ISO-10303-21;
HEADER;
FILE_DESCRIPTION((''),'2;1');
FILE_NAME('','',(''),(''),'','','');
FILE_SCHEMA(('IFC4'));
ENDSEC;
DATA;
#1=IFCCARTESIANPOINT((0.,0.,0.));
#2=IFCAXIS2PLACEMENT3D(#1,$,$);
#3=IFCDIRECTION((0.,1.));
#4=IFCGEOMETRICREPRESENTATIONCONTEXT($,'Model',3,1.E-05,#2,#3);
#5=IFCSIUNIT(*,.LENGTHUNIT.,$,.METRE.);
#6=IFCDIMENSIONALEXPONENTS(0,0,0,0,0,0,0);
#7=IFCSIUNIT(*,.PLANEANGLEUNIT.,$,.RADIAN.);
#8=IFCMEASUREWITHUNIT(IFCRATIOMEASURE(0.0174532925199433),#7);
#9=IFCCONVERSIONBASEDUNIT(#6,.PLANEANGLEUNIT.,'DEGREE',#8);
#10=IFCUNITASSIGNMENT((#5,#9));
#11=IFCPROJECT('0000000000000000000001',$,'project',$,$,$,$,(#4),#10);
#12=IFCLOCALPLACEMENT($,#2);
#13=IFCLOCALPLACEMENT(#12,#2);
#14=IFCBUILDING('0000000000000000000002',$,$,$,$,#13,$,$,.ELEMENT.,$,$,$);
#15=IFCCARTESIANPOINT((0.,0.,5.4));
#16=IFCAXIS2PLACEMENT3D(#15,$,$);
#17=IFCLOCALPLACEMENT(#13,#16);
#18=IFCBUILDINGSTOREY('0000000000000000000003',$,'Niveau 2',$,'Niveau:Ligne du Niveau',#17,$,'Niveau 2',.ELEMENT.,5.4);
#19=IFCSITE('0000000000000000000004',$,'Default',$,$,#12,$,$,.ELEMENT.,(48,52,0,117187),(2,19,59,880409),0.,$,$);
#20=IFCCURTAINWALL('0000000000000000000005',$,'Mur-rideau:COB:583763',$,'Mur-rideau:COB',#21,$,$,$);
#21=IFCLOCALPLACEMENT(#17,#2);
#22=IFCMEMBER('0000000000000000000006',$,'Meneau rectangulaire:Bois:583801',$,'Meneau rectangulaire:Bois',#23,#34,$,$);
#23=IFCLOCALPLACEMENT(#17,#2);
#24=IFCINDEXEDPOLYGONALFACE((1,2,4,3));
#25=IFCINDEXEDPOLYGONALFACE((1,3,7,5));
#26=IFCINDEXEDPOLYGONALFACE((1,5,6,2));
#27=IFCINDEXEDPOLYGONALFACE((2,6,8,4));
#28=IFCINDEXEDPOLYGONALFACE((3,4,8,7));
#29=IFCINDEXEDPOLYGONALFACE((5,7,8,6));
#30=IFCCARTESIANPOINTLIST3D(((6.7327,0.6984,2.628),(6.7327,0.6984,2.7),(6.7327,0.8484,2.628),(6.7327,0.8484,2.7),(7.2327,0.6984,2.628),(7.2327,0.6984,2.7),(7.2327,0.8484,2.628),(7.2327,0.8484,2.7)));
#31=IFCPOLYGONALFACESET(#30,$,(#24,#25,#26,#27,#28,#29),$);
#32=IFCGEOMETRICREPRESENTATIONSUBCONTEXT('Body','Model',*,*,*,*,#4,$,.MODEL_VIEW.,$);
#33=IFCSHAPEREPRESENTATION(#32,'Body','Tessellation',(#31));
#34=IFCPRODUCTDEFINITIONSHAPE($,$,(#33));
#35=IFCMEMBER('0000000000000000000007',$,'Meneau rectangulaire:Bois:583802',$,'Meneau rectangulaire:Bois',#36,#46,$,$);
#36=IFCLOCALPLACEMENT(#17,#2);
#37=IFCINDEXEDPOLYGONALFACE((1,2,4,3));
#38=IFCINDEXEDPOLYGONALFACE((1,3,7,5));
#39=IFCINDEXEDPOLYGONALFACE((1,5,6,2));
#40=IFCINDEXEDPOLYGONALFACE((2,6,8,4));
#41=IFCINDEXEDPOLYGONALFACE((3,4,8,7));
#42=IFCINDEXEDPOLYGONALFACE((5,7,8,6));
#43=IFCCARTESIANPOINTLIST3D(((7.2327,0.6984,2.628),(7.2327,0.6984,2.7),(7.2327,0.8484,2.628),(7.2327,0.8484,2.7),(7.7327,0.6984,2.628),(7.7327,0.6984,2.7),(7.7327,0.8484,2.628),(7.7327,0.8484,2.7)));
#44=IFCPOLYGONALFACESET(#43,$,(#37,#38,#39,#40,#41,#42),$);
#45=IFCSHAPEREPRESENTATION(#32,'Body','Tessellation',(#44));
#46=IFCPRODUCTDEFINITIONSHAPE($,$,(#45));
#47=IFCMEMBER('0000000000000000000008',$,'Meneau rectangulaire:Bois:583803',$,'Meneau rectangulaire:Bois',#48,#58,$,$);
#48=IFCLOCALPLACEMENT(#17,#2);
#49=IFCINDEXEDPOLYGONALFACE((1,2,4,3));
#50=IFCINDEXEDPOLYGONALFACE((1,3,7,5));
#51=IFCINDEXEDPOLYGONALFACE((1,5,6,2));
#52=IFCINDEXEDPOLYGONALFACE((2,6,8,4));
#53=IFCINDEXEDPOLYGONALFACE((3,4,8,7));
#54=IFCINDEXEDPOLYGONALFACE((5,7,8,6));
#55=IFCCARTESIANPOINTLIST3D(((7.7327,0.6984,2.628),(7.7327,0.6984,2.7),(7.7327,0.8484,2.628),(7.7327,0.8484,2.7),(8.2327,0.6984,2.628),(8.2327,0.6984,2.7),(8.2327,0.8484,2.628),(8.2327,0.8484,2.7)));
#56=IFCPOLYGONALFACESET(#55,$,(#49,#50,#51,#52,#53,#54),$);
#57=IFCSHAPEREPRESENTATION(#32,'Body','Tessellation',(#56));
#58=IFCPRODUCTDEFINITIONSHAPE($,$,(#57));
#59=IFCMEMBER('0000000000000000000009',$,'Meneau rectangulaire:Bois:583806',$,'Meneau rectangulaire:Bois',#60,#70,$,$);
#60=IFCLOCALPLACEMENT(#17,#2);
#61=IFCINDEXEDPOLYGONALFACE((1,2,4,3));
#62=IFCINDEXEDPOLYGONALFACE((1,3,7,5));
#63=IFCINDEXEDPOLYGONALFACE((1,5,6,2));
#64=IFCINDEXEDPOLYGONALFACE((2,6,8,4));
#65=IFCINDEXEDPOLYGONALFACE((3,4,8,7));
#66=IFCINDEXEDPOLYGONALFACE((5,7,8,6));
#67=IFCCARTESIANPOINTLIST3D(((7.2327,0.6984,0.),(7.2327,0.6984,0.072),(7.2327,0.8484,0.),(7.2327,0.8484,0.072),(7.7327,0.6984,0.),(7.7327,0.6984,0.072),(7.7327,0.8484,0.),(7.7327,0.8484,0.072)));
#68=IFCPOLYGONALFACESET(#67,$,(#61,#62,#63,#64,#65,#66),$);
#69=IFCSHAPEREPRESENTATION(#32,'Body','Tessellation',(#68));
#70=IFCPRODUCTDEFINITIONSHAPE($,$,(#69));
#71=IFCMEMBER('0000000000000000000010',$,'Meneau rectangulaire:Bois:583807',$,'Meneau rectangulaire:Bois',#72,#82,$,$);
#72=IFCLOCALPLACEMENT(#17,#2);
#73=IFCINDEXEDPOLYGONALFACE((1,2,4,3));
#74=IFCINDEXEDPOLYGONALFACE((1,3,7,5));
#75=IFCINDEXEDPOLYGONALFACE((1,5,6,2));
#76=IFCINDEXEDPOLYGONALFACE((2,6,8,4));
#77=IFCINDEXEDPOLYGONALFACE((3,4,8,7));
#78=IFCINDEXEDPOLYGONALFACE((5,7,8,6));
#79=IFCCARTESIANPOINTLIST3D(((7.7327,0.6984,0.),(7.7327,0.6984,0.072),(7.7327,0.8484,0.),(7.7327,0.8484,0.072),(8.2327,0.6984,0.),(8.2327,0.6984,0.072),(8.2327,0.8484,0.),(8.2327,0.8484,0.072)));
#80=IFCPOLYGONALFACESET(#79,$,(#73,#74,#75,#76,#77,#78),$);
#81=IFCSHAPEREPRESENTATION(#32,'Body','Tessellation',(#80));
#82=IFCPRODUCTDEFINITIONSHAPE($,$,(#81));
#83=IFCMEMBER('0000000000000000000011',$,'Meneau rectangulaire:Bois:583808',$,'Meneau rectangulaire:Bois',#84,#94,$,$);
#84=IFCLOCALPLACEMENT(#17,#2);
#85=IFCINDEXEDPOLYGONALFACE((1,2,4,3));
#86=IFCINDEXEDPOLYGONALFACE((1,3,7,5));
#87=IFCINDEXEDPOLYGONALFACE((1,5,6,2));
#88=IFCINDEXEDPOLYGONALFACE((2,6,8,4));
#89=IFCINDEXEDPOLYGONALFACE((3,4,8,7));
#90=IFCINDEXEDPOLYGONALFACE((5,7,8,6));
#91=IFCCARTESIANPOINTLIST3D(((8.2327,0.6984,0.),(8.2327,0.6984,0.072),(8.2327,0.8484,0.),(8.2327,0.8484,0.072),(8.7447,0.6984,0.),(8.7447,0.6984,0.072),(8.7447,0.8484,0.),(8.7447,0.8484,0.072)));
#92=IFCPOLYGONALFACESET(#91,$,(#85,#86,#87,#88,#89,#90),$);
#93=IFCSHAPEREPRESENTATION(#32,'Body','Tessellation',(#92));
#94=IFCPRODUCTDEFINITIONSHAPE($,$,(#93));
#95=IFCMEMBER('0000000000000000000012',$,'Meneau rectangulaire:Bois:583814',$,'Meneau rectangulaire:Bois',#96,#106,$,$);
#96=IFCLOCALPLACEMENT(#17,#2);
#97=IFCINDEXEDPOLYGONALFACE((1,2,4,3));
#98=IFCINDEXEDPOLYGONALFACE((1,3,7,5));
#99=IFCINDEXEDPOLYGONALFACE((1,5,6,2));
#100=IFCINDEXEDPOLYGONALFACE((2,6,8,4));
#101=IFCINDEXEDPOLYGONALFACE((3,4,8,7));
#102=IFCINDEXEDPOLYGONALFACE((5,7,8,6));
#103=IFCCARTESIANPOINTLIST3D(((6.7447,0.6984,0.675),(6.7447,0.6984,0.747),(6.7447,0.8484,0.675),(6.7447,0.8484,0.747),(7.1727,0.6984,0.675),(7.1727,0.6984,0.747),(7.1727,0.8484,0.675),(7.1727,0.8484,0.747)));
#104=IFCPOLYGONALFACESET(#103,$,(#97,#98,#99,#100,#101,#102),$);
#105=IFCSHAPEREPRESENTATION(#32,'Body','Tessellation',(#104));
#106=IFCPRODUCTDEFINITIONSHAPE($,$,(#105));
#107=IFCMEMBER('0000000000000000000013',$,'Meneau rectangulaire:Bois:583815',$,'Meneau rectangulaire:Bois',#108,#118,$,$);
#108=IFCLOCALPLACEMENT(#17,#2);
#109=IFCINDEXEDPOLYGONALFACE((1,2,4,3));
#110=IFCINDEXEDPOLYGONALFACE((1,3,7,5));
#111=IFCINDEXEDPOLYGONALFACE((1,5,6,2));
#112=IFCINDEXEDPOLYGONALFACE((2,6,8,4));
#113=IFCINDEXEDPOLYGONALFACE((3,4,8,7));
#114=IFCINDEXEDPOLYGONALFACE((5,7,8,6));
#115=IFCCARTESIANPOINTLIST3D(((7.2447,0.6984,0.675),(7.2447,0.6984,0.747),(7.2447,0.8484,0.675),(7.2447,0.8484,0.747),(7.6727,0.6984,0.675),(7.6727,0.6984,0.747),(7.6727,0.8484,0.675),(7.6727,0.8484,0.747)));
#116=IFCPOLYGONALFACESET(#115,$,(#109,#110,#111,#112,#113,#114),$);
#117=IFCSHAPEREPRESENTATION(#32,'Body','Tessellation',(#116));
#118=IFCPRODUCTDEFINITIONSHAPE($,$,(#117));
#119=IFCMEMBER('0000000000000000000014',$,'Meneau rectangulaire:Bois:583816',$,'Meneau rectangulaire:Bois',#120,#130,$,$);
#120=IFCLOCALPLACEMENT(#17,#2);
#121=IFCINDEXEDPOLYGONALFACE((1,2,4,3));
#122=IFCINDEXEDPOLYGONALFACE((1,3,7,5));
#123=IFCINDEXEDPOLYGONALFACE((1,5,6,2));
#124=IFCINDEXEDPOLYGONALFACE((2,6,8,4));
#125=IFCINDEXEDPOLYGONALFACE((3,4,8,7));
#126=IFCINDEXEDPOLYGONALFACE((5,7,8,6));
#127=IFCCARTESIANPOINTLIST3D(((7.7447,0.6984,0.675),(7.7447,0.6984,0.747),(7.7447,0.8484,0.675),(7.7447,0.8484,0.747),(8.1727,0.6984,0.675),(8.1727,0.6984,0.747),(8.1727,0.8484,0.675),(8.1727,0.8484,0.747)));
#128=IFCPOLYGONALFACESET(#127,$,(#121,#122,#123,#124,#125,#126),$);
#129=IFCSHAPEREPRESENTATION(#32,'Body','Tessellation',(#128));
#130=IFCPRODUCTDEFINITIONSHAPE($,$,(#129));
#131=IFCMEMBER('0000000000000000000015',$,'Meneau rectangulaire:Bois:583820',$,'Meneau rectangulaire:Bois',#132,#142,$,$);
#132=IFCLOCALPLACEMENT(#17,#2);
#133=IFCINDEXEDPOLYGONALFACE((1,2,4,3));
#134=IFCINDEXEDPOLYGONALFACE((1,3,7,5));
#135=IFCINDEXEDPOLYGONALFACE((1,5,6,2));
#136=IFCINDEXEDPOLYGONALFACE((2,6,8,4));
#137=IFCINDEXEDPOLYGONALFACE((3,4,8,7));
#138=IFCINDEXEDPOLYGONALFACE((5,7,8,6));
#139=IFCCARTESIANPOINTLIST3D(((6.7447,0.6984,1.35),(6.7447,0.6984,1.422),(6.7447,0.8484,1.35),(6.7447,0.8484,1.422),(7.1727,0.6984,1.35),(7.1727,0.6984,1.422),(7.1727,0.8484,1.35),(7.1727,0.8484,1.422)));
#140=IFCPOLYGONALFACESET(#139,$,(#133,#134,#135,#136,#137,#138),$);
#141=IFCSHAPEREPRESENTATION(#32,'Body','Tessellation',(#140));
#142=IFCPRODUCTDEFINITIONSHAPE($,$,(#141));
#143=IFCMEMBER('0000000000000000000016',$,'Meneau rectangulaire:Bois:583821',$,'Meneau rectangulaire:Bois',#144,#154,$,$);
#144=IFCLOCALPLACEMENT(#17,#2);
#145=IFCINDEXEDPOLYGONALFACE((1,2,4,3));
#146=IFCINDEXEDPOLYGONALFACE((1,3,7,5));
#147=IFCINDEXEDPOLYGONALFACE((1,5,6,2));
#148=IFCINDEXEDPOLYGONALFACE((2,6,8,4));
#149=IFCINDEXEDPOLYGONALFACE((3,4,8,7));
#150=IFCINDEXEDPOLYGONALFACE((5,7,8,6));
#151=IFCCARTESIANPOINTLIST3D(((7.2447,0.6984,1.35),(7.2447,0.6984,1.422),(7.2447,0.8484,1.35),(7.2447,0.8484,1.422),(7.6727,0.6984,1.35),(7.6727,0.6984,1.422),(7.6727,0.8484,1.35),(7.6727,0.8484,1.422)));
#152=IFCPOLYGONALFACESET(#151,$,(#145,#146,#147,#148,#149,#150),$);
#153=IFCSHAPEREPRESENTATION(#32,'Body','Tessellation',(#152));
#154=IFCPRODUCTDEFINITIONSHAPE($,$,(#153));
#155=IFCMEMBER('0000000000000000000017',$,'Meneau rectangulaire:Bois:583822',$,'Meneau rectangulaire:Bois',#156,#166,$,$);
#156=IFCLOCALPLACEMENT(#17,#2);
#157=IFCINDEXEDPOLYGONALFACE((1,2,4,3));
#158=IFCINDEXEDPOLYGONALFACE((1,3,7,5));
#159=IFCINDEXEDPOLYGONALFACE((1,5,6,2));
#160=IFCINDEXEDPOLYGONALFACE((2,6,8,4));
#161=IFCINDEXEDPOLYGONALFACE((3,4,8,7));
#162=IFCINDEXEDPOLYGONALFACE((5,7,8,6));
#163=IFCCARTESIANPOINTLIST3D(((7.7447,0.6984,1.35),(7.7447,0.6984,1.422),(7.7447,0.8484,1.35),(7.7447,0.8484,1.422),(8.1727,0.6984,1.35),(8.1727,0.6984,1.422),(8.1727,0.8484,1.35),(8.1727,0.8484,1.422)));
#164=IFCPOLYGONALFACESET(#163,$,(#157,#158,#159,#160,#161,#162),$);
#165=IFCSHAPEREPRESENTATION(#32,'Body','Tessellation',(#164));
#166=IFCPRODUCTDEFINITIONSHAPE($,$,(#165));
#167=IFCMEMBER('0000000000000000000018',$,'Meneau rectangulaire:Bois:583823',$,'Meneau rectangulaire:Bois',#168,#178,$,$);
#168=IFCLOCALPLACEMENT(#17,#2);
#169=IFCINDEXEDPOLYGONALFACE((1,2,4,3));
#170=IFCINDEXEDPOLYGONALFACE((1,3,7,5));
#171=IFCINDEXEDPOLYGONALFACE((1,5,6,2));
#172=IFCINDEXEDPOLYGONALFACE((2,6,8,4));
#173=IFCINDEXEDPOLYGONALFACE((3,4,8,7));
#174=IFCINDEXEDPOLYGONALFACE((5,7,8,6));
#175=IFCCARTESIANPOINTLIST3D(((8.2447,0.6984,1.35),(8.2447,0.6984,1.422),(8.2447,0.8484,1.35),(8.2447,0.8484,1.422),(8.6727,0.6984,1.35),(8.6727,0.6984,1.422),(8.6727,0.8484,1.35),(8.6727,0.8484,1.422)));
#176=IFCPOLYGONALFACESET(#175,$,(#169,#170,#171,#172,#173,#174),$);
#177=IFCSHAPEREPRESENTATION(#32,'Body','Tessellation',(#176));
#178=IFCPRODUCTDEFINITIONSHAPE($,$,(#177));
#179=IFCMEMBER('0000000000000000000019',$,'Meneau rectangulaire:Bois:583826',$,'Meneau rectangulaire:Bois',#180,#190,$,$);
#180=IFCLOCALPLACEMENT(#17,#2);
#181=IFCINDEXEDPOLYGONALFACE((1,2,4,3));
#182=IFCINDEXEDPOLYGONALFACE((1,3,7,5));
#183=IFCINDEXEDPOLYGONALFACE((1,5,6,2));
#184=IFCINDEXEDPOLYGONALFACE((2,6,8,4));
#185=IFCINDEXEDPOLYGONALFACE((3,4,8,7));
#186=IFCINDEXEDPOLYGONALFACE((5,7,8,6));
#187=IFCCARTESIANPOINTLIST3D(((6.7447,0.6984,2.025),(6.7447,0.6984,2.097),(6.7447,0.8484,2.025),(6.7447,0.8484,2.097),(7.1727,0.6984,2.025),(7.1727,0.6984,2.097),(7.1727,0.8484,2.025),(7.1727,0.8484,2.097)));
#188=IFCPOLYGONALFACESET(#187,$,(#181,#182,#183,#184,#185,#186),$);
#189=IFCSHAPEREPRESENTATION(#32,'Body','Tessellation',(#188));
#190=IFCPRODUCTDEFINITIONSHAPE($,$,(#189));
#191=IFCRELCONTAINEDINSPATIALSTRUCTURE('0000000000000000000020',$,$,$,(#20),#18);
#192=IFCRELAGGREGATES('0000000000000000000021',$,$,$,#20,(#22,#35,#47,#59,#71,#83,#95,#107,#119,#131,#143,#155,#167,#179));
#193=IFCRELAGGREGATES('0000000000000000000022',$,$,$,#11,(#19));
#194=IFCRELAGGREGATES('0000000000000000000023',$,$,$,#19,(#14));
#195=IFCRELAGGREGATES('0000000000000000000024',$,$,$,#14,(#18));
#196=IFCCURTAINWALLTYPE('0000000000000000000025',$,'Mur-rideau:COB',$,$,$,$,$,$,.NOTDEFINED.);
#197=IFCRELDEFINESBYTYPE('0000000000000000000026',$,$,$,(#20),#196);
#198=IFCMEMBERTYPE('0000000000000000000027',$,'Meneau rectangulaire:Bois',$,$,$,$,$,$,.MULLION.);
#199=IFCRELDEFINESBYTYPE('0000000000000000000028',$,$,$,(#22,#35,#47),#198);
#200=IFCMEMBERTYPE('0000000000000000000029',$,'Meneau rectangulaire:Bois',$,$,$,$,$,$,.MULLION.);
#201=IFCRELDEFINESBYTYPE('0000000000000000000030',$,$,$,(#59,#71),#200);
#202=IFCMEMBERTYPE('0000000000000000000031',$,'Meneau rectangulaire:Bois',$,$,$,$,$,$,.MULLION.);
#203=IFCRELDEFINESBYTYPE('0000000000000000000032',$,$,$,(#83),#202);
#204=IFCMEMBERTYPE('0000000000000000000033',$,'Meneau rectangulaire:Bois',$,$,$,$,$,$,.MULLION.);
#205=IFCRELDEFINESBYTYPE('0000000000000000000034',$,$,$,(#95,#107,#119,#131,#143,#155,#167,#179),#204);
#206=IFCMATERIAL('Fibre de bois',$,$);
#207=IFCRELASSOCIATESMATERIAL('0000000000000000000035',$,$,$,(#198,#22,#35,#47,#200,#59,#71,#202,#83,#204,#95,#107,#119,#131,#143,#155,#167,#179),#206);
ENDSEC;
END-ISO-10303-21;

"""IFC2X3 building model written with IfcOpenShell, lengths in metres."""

from ifc_helpers import new_model, entity, si_unit, converted_unit, direction, frame, origin, origin_2d_with_axis, place, context, subcontext, project, spatial, rectangle, extrude, source, transform, mapped, material, type_object, type_shapes, element, aggregate, save


model = new_model("IFC2X3")

# Units and contexts
model_context = context("Model", 3, precision=1e-05, world=origin(), true_north=direction((0.0, 1.0)))
body_context = subcontext(model_context, "Body", "Model", "MODEL_VIEW")
ifc_project = project(units=[si_unit("LENGTHUNIT", "METRE"), converted_unit("PLANEANGLEUNIT", "DEGREE", entity("IfcRatioMeasure", 0.0174532925199433), si_unit("PLANEANGLEUNIT", "RADIAN"), dimensions=[0, 0, 0, 0, 0, 0, 0])], contexts=[model_context])

# Site, building, storey
site_placement = place(None, origin())
site = spatial("IfcSite", under=ifc_project, at=site_placement, Name="Default", CompositionType="ELEMENT", RefLatitude=(48, 52, 0, 117187), RefLongitude=(2, 19, 59, 880409), RefElevation=0.0)
building_placement = place(site_placement, origin())
building = spatial("IfcBuilding", under=site, at=building_placement, CompositionType="ELEMENT")
storey_placement = place(building_placement, frame((0.0, 0.0, 5.4)))
storey = spatial("IfcBuildingStorey", under=building, at=storey_placement, Name="Niveau 2", ObjectType="Niveau:Ligne du Niveau", LongName="Niveau 2", CompositionType="ELEMENT", Elevation=5.4)

# Curtain wall, members
curtain_wall_type_1 = type_object("IfcCurtainWallType", Name="Mur-rideau:COB", PredefinedType="NOTDEFINED")
curtain_wall_1_placement = place(storey_placement, frame((0.0, 0.0, -5.4)))
curtain_wall_1 = element("IfcCurtainWall", 1, at=curtain_wall_1_placement, inside=storey, type_object=curtain_wall_type_1, Name="Mur-rideau:COB:583763", ObjectType="Mur-rideau:COB")
ifc_material_1 = material(Name="Fibre de bois")
member_type_1 = type_object("IfcMemberType", Name="Meneau rectangulaire:Bois", PredefinedType="MULLION", material=ifc_material_1)
shared_shape_1 = source(origin(), body_context, "Body", "SweptSolid", [
    extrude(rectangle(XDim=0.15, YDim=0.072, at=origin_2d_with_axis()), frame((-0.036, 0.0, -0.5), z_axis=(0.0, 0.0, 1.0), x_axis=(0.0, -1.0, 0.0)), (0.0, 0.0, 1.0), 0.5),
])
type_shapes(member_type_1, [shared_shape_1])
member_1_placement = place(storey_placement, frame((7.2327, 0.7734, 2.7), z_axis=(1.0, 0.0, 0.0), x_axis=(0.0, 0.0, 1.0)))
member_1 = element("IfcMember", 2, at=member_1_placement, type_object=member_type_1, material=ifc_material_1, Name="Meneau rectangulaire:Bois:583801", ObjectType="Meneau rectangulaire:Bois", context=body_context, shape_type="MappedRepresentation", body=[
    mapped(shared_shape_1, transform((0.0, 0.0, 0.0), scale=1.0)),
])
member_2_placement = place(storey_placement, frame((7.7327, 0.7734, 2.7), z_axis=(1.0, 0.0, 0.0), x_axis=(0.0, 0.0, 1.0)))
member_2 = element("IfcMember", 3, at=member_2_placement, type_object=member_type_1, material=ifc_material_1, Name="Meneau rectangulaire:Bois:583802", ObjectType="Meneau rectangulaire:Bois", context=body_context, shape_type="MappedRepresentation", body=[
    mapped(shared_shape_1, transform((0.0, 0.0, 0.0), scale=1.0)),
])
member_3_placement = place(storey_placement, frame((8.2327, 0.7734, 2.7), z_axis=(1.0, 0.0, 0.0), x_axis=(0.0, 0.0, 1.0)))
member_3 = element("IfcMember", 4, at=member_3_placement, type_object=member_type_1, material=ifc_material_1, Name="Meneau rectangulaire:Bois:583803", ObjectType="Meneau rectangulaire:Bois", context=body_context, shape_type="MappedRepresentation", body=[
    mapped(shared_shape_1, transform((0.0, 0.0, 0.0), scale=1.0)),
])
member_type_2 = type_object("IfcMemberType", Name="Meneau rectangulaire:Bois", PredefinedType="MULLION", material=ifc_material_1)
shared_shape_2 = source(origin(), body_context, "Body", "SweptSolid", [
    extrude(rectangle(XDim=0.15, YDim=0.072, at=origin_2d_with_axis()), frame((-0.036, 0.0, -0.5), z_axis=(0.0, 0.0, 1.0), x_axis=(0.0, -1.0, 0.0)), (0.0, 0.0, 1.0), 0.5),
])
type_shapes(member_type_2, [shared_shape_2])
member_4_placement = place(storey_placement, frame((7.2327, 0.7734, 0.0), z_axis=(-1.0, 0.0, 0.0), x_axis=(0.0, 0.0, -1.0)))
member_4 = element("IfcMember", 5, at=member_4_placement, type_object=member_type_2, material=ifc_material_1, Name="Meneau rectangulaire:Bois:583806", ObjectType="Meneau rectangulaire:Bois", context=body_context, shape_type="MappedRepresentation", body=[
    mapped(shared_shape_2, transform((0.0, 0.0, 0.0), scale=1.0)),
])
member_5_placement = place(storey_placement, frame((7.7327, 0.7734, 0.0), z_axis=(-1.0, 0.0, 0.0), x_axis=(0.0, 0.0, -1.0)))
member_5 = element("IfcMember", 6, at=member_5_placement, type_object=member_type_2, material=ifc_material_1, Name="Meneau rectangulaire:Bois:583807", ObjectType="Meneau rectangulaire:Bois", context=body_context, shape_type="MappedRepresentation", body=[
    mapped(shared_shape_2, transform((0.0, 0.0, 0.0), scale=1.0)),
])
member_type_3 = type_object("IfcMemberType", Name="Meneau rectangulaire:Bois", PredefinedType="MULLION", material=ifc_material_1)
shared_shape_3 = source(origin(), body_context, "Body", "SweptSolid", [
    extrude(rectangle(XDim=0.15, YDim=0.072, at=origin_2d_with_axis()), frame((-0.036, 0.0, -0.512), z_axis=(0.0, 0.0, 1.0), x_axis=(0.0, -1.0, 0.0)), (0.0, 0.0, 1.0), 0.512),
])
type_shapes(member_type_3, [shared_shape_3])
member_6_placement = place(storey_placement, frame((8.2327, 0.7734, 0.0), z_axis=(-1.0, 0.0, 0.0), x_axis=(0.0, 0.0, -1.0)))
member_6 = element("IfcMember", 7, at=member_6_placement, type_object=member_type_3, material=ifc_material_1, Name="Meneau rectangulaire:Bois:583808", ObjectType="Meneau rectangulaire:Bois", context=body_context, shape_type="MappedRepresentation", body=[
    mapped(shared_shape_3, transform((0.0, 0.0, 0.0), scale=1.0)),
])
member_type_4 = type_object("IfcMemberType", Name="Meneau rectangulaire:Bois", PredefinedType="MULLION", material=ifc_material_1)
shared_shape_4 = source(origin(), body_context, "Body", "SweptSolid", [
    extrude(rectangle(XDim=0.15, YDim=0.072, at=origin_2d_with_axis()), frame((-0.024, 0.0, -0.428), z_axis=(0.0, 0.0, 1.0), x_axis=(0.0, -1.0, 0.0)), (0.0, 0.0, 1.0), 0.428),
])
type_shapes(member_type_4, [shared_shape_4])
member_7_placement = place(storey_placement, frame((7.1727, 0.7734, 0.735), z_axis=(1.0, 0.0, 0.0), x_axis=(0.0, 0.0, 1.0)))
member_7 = element("IfcMember", 8, at=member_7_placement, type_object=member_type_4, material=ifc_material_1, Name="Meneau rectangulaire:Bois:583814", ObjectType="Meneau rectangulaire:Bois", context=body_context, shape_type="MappedRepresentation", body=[
    mapped(shared_shape_4, transform((0.0, 0.0, 0.0), scale=1.0)),
])
member_8_placement = place(storey_placement, frame((7.6727, 0.7734, 0.735), z_axis=(1.0, 0.0, 0.0), x_axis=(0.0, 0.0, 1.0)))
member_8 = element("IfcMember", 9, at=member_8_placement, type_object=member_type_4, material=ifc_material_1, Name="Meneau rectangulaire:Bois:583815", ObjectType="Meneau rectangulaire:Bois", context=body_context, shape_type="MappedRepresentation", body=[
    mapped(shared_shape_4, transform((0.0, 0.0, 0.0), scale=1.0)),
])
member_9_placement = place(storey_placement, frame((8.1727, 0.7734, 0.735), z_axis=(1.0, 0.0, 0.0), x_axis=(0.0, 0.0, 1.0)))
member_9 = element("IfcMember", 10, at=member_9_placement, type_object=member_type_4, material=ifc_material_1, Name="Meneau rectangulaire:Bois:583816", ObjectType="Meneau rectangulaire:Bois", context=body_context, shape_type="MappedRepresentation", body=[
    mapped(shared_shape_4, transform((0.0, 0.0, 0.0), scale=1.0)),
])
member_10_placement = place(storey_placement, frame((7.1727, 0.7734, 1.41), z_axis=(1.0, 0.0, 0.0), x_axis=(0.0, 0.0, 1.0)))
member_10 = element("IfcMember", 11, at=member_10_placement, type_object=member_type_4, material=ifc_material_1, Name="Meneau rectangulaire:Bois:583820", ObjectType="Meneau rectangulaire:Bois", context=body_context, shape_type="MappedRepresentation", body=[
    mapped(shared_shape_4, transform((0.0, 0.0, 0.0), scale=1.0)),
])
member_11_placement = place(storey_placement, frame((7.6727, 0.7734, 1.41), z_axis=(1.0, 0.0, 0.0), x_axis=(0.0, 0.0, 1.0)))
member_11 = element("IfcMember", 12, at=member_11_placement, type_object=member_type_4, material=ifc_material_1, Name="Meneau rectangulaire:Bois:583821", ObjectType="Meneau rectangulaire:Bois", context=body_context, shape_type="MappedRepresentation", body=[
    mapped(shared_shape_4, transform((0.0, 0.0, 0.0), scale=1.0)),
])
member_12_placement = place(storey_placement, frame((8.1727, 0.7734, 1.41), z_axis=(1.0, 0.0, 0.0), x_axis=(0.0, 0.0, 1.0)))
member_12 = element("IfcMember", 13, at=member_12_placement, type_object=member_type_4, material=ifc_material_1, Name="Meneau rectangulaire:Bois:583822", ObjectType="Meneau rectangulaire:Bois", context=body_context, shape_type="MappedRepresentation", body=[
    mapped(shared_shape_4, transform((0.0, 0.0, 0.0), scale=1.0)),
])
member_13_placement = place(storey_placement, frame((8.6727, 0.7734, 1.41), z_axis=(1.0, 0.0, 0.0), x_axis=(0.0, 0.0, 1.0)))
member_13 = element("IfcMember", 14, at=member_13_placement, type_object=member_type_4, material=ifc_material_1, Name="Meneau rectangulaire:Bois:583823", ObjectType="Meneau rectangulaire:Bois", context=body_context, shape_type="MappedRepresentation", body=[
    mapped(shared_shape_4, transform((0.0, 0.0, 0.0), scale=1.0)),
])
member_14_placement = place(storey_placement, frame((7.1727, 0.7734, 2.085), z_axis=(1.0, 0.0, 0.0), x_axis=(0.0, 0.0, 1.0)))
member_14 = element("IfcMember", 15, at=member_14_placement, type_object=member_type_4, material=ifc_material_1, Name="Meneau rectangulaire:Bois:583826", ObjectType="Meneau rectangulaire:Bois", context=body_context, shape_type="MappedRepresentation", body=[
    mapped(shared_shape_4, transform((0.0, 0.0, 0.0), scale=1.0)),
])
aggregate(curtain_wall_1, [member_1, member_2, member_3, member_4, member_5, member_6, member_7, member_8, member_9, member_10, member_11, member_12, member_13, member_14])

save(model, "model.ifc")
